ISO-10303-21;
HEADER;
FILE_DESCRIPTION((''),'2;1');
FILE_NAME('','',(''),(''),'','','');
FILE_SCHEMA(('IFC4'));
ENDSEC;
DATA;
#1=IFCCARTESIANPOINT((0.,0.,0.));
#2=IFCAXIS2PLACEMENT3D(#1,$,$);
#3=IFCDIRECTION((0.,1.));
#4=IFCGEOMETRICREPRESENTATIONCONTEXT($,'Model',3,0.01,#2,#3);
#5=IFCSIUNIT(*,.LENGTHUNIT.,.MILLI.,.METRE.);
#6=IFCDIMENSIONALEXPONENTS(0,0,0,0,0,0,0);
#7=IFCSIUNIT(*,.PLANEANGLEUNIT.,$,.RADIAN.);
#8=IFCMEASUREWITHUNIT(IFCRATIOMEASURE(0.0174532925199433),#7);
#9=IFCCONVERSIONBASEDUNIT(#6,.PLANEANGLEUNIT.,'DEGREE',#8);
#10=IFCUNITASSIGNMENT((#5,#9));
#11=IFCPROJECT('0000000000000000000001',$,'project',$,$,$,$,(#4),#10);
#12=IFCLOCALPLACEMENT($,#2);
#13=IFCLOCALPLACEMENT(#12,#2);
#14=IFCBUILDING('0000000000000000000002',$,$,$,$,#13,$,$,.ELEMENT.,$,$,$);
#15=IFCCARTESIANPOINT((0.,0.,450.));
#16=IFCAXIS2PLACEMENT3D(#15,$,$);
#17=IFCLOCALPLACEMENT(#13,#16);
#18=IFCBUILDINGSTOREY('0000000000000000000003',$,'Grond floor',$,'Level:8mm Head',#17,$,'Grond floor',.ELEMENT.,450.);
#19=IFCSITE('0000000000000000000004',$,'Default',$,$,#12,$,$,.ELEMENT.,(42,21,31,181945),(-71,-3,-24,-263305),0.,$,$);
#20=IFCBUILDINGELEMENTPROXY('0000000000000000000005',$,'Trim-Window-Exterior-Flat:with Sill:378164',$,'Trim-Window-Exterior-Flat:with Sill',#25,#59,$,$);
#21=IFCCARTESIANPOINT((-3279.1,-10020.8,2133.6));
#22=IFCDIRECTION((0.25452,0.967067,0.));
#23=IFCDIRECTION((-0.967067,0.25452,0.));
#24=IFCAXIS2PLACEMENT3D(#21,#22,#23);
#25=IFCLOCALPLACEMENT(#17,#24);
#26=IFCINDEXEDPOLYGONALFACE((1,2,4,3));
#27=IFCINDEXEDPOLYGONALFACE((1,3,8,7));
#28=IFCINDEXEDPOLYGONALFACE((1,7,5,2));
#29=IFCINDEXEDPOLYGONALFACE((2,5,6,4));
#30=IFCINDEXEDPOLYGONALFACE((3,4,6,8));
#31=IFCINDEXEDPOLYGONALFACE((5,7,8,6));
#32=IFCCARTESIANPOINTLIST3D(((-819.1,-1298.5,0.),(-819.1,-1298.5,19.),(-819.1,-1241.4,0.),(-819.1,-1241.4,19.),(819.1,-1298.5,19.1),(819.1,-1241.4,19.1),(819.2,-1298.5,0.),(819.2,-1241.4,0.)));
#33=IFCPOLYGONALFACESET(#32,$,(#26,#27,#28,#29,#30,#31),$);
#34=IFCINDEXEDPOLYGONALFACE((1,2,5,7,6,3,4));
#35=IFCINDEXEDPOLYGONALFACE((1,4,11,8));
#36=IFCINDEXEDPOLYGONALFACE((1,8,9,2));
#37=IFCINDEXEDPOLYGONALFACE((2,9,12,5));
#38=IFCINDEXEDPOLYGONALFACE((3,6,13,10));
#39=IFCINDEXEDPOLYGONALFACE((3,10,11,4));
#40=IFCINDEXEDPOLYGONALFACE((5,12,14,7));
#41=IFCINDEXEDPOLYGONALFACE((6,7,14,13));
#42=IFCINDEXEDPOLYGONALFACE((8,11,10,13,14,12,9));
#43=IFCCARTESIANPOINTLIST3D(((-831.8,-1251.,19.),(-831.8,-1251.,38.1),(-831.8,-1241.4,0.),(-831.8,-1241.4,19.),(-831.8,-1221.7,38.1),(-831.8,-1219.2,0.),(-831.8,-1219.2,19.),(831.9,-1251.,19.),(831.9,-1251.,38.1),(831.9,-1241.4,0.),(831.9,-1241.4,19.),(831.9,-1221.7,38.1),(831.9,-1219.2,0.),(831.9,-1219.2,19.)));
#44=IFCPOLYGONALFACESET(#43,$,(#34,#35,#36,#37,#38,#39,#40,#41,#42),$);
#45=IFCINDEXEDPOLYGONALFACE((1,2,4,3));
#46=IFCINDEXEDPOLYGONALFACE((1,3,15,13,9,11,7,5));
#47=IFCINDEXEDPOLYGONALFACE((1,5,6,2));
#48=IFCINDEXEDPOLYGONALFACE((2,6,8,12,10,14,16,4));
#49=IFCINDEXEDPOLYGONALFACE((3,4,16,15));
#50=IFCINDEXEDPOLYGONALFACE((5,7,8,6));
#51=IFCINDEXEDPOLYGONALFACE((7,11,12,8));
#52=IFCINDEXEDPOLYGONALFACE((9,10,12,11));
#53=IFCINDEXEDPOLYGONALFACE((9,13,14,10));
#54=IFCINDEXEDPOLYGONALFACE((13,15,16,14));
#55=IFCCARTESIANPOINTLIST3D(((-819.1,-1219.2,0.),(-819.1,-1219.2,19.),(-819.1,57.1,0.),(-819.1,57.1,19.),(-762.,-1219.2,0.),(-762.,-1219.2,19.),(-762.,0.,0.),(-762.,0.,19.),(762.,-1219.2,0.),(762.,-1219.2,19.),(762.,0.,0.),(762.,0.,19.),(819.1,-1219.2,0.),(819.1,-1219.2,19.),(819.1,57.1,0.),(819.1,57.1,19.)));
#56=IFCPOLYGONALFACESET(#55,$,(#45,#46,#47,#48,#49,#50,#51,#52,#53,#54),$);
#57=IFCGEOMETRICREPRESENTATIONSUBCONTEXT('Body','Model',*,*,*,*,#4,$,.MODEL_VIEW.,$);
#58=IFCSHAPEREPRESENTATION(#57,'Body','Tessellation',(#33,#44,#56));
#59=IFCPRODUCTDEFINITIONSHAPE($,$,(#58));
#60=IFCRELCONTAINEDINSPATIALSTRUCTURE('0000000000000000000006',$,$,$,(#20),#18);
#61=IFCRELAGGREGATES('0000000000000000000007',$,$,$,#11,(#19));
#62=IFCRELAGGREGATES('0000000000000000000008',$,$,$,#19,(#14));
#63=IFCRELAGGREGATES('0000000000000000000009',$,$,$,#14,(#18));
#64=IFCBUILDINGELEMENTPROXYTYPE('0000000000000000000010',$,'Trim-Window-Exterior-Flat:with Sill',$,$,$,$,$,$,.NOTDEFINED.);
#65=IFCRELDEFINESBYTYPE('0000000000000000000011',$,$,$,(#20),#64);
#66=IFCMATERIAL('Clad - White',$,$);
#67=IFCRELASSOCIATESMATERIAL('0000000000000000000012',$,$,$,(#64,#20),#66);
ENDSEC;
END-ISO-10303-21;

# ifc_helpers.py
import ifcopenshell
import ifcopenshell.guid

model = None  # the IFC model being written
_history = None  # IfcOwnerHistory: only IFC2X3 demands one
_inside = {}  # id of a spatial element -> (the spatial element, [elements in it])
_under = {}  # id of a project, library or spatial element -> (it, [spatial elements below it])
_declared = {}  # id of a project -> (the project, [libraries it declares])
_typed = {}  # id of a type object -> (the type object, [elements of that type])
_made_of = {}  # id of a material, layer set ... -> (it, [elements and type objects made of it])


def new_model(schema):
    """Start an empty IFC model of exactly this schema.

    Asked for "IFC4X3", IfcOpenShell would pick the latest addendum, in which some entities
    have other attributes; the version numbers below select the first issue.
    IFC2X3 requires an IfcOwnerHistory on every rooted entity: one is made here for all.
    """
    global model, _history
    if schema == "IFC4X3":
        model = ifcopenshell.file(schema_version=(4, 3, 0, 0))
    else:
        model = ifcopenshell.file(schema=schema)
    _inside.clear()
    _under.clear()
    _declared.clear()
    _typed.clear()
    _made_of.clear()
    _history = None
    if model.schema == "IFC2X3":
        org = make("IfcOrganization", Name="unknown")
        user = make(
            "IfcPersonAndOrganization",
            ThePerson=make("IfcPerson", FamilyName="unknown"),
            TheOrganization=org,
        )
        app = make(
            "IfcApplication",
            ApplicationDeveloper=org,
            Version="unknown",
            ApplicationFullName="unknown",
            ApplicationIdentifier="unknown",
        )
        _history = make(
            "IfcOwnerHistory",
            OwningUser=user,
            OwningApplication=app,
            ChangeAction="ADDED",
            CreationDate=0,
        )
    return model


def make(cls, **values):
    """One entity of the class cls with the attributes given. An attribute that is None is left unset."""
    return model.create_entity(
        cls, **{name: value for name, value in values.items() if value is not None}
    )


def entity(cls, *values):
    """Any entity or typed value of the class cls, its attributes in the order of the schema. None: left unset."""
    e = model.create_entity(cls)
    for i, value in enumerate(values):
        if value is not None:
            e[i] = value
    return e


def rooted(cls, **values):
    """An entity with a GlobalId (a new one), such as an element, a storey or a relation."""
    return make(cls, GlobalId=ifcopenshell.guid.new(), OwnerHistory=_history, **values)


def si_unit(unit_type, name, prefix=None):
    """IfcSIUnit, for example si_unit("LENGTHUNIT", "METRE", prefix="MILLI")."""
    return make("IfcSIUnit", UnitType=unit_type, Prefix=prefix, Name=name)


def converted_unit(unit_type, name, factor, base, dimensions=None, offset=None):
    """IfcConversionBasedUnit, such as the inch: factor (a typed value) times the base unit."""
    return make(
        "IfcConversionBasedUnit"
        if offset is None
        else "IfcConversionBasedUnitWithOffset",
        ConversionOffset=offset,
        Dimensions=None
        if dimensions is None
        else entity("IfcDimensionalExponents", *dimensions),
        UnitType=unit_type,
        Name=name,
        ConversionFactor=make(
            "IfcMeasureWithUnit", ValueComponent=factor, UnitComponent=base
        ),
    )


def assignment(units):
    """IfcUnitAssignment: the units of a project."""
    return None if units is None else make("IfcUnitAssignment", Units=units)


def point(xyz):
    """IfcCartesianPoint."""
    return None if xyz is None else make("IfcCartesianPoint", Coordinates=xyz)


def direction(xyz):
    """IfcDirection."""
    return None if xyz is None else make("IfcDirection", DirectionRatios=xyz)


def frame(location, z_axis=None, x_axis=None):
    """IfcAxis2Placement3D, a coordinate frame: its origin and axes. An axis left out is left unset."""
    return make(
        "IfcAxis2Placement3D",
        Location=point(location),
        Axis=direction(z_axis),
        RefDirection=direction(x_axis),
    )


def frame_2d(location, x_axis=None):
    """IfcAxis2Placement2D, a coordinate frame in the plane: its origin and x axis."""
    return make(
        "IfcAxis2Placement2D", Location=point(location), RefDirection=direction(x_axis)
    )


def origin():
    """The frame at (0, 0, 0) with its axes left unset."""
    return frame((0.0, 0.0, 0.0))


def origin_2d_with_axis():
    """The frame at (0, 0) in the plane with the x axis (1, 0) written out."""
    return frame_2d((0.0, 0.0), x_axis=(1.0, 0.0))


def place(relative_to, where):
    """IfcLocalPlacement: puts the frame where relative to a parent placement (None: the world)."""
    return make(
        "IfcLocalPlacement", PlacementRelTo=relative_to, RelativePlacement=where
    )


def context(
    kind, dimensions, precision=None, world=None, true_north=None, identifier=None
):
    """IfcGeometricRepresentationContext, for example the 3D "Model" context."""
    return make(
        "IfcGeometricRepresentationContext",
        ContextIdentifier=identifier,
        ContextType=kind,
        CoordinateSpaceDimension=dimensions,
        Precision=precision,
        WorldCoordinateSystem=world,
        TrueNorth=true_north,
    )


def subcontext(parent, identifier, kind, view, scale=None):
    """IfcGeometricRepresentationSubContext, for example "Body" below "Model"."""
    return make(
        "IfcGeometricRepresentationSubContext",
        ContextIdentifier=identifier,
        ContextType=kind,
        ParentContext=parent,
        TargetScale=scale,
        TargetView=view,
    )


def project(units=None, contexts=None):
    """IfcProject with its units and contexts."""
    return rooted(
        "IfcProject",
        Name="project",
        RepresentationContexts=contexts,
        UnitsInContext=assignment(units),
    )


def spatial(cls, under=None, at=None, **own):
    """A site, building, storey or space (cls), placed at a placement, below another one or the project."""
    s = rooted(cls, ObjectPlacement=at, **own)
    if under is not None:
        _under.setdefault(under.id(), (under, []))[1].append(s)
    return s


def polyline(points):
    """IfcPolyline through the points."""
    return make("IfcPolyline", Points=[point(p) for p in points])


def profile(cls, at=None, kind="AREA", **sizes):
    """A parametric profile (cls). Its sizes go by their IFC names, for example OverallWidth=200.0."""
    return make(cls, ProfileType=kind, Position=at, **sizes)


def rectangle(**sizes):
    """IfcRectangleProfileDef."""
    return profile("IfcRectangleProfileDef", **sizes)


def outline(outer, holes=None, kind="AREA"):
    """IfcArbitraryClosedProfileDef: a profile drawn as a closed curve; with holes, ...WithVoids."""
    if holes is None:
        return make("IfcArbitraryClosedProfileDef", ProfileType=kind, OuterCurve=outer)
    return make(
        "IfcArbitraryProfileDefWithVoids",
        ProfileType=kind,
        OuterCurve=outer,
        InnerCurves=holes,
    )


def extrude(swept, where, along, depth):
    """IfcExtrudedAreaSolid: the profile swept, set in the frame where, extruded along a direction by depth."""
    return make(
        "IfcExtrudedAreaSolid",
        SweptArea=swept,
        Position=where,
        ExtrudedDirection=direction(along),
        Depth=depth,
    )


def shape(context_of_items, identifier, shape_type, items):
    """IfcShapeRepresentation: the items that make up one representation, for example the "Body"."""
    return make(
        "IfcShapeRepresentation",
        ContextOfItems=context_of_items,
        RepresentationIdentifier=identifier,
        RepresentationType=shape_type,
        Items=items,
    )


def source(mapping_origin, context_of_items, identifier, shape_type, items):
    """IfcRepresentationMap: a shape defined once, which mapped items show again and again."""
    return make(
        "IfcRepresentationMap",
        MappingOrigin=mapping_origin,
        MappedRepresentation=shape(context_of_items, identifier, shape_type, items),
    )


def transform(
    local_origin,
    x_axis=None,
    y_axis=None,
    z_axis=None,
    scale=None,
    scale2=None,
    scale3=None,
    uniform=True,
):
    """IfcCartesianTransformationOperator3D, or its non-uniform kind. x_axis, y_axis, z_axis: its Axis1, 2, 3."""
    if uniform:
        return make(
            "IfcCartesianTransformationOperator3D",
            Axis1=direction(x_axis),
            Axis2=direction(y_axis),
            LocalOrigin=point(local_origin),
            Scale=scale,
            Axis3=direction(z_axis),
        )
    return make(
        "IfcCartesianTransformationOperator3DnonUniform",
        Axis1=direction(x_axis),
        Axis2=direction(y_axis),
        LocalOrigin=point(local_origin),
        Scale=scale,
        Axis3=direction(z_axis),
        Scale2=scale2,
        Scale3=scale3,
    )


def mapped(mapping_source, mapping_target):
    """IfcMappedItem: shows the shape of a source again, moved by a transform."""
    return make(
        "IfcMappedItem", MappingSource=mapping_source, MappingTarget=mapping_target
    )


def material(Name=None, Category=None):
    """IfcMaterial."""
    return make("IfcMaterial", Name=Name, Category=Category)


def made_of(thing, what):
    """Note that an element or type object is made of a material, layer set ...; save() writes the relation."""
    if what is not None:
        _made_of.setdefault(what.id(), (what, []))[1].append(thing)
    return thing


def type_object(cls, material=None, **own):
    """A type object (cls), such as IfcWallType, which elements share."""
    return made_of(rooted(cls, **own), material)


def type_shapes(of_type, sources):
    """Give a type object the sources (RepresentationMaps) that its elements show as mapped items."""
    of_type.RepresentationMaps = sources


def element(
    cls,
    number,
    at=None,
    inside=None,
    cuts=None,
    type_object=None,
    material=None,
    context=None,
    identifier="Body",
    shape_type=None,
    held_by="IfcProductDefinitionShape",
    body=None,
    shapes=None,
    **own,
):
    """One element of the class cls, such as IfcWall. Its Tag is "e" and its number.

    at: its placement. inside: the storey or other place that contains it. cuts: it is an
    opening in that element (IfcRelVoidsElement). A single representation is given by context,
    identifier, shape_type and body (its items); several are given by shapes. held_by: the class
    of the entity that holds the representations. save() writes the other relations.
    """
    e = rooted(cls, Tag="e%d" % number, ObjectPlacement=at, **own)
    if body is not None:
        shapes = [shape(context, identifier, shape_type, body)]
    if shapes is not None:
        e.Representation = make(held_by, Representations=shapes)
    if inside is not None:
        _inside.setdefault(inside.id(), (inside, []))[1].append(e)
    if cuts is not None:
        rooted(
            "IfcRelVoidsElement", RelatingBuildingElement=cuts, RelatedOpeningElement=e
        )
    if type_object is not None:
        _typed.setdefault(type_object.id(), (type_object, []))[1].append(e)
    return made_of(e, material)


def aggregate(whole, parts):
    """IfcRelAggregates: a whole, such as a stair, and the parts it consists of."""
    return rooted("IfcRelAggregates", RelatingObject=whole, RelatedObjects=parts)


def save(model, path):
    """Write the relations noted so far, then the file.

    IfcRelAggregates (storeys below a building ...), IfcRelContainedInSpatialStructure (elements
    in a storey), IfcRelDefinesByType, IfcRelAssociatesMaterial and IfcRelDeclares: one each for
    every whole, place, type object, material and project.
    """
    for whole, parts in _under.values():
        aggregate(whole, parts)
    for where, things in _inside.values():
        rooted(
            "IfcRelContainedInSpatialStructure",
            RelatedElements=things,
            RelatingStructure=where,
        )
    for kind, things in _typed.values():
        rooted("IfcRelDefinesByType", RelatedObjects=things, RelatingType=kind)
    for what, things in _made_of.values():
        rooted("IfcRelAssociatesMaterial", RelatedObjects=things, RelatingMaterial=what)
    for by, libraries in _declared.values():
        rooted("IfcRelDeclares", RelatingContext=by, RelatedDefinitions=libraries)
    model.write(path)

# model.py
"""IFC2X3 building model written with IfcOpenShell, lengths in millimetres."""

from ifc_helpers import new_model, entity, si_unit, converted_unit, direction, frame, origin, origin_2d_with_axis, place, context, subcontext, project, spatial, polyline, rectangle, outline, extrude, source, transform, mapped, material, type_object, type_shapes, element, save


model = new_model("IFC2X3")

# Units and contexts
model_context = context("Model", 3, precision=0.01, world=origin(), true_north=direction((0.0, 1.0)))
body_context = subcontext(model_context, "Body", "Model", "MODEL_VIEW")
ifc_project = project(units=[si_unit("LENGTHUNIT", "METRE", prefix="MILLI"), converted_unit("PLANEANGLEUNIT", "DEGREE", entity("IfcRatioMeasure", 0.0174532925199433), si_unit("PLANEANGLEUNIT", "RADIAN"), dimensions=[0, 0, 0, 0, 0, 0, 0])], contexts=[model_context])

# Site, building, storey
site_placement = place(None, origin())
site = spatial("IfcSite", under=ifc_project, at=site_placement, Name="Default", CompositionType="ELEMENT", RefLatitude=(42, 21, 31, 181945), RefLongitude=(-71, -3, -24, -263305), RefElevation=0.0)
building_placement = place(site_placement, origin())
building = spatial("IfcBuilding", under=site, at=building_placement, CompositionType="ELEMENT")
storey_placement = place(building_placement, frame((0.0, 0.0, 450.0)))
storey = spatial("IfcBuildingStorey", under=building, at=storey_placement, Name="Grond floor", ObjectType="Level:8mm Head", LongName="Grond floor", CompositionType="ELEMENT", Elevation=450.0)

# Building element proxy
ifc_material_1 = material(Name="Clad - White")
building_element_proxy_type_1 = type_object("IfcBuildingElementProxyType", Name="Trim-Window-Exterior-Flat:with Sill", PredefinedType="NOTDEFINED", material=ifc_material_1)
shared_shape_1 = source(origin(), body_context, "Body", "SweptSolid", [
    extrude(rectangle(XDim=1638.3, YDim=57.2, at=origin_2d_with_axis()), frame((0.0, -1270.0, 0.0), z_axis=(0.0, 0.0, 1.0), x_axis=(-1.0, 0.0, 0.0)), (0.0, 0.0, 1.0), 19.1),
    extrude(outline(polyline([(-19.0, -16.0), (0.0, -16.0), (0.0, -6.4), (19.0, -6.4), (19.0, 15.8), (0.0, 15.8), (-19.0, 13.3), (-19.0, -16.0)])), frame((-831.8, -1235.0, 19.0), z_axis=(1.0, 0.0, 0.0), x_axis=(0.0, 0.0, -1.0)), (0.0, 0.0, 1.0), 1663.7),
    extrude(outline(polyline([(-652.5, -819.1), (623.9, -819.1), (623.9, -762.0), (-595.3, -762.0), (-595.3, 762.0), (623.9, 762.0), (623.9, 819.1), (-652.5, 819.1), (-652.5, -819.1)])), frame((0.0, -595.3, 0.0), z_axis=(0.0, 0.0, 1.0), x_axis=(0.0, -1.0, 0.0)), (0.0, 0.0, 1.0), 19.1),
])
type_shapes(building_element_proxy_type_1, [shared_shape_1])
proxy_1_placement = place(storey_placement, frame((-3279.1, -10020.8, 2133.6), z_axis=(0.25452, 0.967067, 0.0), x_axis=(-0.967067, 0.25452, 0.0)))
element("IfcBuildingElementProxy", 1, at=proxy_1_placement, inside=storey, type_object=building_element_proxy_type_1, material=ifc_material_1, Name="Trim-Window-Exterior-Flat:with Sill:378164", ObjectType="Trim-Window-Exterior-Flat:with Sill", context=body_context, shape_type="MappedRepresentation", body=[
    mapped(shared_shape_1, transform((0.0, 0.0, 0.0), scale=1.0)),
])

save(model, "model.ifc")
